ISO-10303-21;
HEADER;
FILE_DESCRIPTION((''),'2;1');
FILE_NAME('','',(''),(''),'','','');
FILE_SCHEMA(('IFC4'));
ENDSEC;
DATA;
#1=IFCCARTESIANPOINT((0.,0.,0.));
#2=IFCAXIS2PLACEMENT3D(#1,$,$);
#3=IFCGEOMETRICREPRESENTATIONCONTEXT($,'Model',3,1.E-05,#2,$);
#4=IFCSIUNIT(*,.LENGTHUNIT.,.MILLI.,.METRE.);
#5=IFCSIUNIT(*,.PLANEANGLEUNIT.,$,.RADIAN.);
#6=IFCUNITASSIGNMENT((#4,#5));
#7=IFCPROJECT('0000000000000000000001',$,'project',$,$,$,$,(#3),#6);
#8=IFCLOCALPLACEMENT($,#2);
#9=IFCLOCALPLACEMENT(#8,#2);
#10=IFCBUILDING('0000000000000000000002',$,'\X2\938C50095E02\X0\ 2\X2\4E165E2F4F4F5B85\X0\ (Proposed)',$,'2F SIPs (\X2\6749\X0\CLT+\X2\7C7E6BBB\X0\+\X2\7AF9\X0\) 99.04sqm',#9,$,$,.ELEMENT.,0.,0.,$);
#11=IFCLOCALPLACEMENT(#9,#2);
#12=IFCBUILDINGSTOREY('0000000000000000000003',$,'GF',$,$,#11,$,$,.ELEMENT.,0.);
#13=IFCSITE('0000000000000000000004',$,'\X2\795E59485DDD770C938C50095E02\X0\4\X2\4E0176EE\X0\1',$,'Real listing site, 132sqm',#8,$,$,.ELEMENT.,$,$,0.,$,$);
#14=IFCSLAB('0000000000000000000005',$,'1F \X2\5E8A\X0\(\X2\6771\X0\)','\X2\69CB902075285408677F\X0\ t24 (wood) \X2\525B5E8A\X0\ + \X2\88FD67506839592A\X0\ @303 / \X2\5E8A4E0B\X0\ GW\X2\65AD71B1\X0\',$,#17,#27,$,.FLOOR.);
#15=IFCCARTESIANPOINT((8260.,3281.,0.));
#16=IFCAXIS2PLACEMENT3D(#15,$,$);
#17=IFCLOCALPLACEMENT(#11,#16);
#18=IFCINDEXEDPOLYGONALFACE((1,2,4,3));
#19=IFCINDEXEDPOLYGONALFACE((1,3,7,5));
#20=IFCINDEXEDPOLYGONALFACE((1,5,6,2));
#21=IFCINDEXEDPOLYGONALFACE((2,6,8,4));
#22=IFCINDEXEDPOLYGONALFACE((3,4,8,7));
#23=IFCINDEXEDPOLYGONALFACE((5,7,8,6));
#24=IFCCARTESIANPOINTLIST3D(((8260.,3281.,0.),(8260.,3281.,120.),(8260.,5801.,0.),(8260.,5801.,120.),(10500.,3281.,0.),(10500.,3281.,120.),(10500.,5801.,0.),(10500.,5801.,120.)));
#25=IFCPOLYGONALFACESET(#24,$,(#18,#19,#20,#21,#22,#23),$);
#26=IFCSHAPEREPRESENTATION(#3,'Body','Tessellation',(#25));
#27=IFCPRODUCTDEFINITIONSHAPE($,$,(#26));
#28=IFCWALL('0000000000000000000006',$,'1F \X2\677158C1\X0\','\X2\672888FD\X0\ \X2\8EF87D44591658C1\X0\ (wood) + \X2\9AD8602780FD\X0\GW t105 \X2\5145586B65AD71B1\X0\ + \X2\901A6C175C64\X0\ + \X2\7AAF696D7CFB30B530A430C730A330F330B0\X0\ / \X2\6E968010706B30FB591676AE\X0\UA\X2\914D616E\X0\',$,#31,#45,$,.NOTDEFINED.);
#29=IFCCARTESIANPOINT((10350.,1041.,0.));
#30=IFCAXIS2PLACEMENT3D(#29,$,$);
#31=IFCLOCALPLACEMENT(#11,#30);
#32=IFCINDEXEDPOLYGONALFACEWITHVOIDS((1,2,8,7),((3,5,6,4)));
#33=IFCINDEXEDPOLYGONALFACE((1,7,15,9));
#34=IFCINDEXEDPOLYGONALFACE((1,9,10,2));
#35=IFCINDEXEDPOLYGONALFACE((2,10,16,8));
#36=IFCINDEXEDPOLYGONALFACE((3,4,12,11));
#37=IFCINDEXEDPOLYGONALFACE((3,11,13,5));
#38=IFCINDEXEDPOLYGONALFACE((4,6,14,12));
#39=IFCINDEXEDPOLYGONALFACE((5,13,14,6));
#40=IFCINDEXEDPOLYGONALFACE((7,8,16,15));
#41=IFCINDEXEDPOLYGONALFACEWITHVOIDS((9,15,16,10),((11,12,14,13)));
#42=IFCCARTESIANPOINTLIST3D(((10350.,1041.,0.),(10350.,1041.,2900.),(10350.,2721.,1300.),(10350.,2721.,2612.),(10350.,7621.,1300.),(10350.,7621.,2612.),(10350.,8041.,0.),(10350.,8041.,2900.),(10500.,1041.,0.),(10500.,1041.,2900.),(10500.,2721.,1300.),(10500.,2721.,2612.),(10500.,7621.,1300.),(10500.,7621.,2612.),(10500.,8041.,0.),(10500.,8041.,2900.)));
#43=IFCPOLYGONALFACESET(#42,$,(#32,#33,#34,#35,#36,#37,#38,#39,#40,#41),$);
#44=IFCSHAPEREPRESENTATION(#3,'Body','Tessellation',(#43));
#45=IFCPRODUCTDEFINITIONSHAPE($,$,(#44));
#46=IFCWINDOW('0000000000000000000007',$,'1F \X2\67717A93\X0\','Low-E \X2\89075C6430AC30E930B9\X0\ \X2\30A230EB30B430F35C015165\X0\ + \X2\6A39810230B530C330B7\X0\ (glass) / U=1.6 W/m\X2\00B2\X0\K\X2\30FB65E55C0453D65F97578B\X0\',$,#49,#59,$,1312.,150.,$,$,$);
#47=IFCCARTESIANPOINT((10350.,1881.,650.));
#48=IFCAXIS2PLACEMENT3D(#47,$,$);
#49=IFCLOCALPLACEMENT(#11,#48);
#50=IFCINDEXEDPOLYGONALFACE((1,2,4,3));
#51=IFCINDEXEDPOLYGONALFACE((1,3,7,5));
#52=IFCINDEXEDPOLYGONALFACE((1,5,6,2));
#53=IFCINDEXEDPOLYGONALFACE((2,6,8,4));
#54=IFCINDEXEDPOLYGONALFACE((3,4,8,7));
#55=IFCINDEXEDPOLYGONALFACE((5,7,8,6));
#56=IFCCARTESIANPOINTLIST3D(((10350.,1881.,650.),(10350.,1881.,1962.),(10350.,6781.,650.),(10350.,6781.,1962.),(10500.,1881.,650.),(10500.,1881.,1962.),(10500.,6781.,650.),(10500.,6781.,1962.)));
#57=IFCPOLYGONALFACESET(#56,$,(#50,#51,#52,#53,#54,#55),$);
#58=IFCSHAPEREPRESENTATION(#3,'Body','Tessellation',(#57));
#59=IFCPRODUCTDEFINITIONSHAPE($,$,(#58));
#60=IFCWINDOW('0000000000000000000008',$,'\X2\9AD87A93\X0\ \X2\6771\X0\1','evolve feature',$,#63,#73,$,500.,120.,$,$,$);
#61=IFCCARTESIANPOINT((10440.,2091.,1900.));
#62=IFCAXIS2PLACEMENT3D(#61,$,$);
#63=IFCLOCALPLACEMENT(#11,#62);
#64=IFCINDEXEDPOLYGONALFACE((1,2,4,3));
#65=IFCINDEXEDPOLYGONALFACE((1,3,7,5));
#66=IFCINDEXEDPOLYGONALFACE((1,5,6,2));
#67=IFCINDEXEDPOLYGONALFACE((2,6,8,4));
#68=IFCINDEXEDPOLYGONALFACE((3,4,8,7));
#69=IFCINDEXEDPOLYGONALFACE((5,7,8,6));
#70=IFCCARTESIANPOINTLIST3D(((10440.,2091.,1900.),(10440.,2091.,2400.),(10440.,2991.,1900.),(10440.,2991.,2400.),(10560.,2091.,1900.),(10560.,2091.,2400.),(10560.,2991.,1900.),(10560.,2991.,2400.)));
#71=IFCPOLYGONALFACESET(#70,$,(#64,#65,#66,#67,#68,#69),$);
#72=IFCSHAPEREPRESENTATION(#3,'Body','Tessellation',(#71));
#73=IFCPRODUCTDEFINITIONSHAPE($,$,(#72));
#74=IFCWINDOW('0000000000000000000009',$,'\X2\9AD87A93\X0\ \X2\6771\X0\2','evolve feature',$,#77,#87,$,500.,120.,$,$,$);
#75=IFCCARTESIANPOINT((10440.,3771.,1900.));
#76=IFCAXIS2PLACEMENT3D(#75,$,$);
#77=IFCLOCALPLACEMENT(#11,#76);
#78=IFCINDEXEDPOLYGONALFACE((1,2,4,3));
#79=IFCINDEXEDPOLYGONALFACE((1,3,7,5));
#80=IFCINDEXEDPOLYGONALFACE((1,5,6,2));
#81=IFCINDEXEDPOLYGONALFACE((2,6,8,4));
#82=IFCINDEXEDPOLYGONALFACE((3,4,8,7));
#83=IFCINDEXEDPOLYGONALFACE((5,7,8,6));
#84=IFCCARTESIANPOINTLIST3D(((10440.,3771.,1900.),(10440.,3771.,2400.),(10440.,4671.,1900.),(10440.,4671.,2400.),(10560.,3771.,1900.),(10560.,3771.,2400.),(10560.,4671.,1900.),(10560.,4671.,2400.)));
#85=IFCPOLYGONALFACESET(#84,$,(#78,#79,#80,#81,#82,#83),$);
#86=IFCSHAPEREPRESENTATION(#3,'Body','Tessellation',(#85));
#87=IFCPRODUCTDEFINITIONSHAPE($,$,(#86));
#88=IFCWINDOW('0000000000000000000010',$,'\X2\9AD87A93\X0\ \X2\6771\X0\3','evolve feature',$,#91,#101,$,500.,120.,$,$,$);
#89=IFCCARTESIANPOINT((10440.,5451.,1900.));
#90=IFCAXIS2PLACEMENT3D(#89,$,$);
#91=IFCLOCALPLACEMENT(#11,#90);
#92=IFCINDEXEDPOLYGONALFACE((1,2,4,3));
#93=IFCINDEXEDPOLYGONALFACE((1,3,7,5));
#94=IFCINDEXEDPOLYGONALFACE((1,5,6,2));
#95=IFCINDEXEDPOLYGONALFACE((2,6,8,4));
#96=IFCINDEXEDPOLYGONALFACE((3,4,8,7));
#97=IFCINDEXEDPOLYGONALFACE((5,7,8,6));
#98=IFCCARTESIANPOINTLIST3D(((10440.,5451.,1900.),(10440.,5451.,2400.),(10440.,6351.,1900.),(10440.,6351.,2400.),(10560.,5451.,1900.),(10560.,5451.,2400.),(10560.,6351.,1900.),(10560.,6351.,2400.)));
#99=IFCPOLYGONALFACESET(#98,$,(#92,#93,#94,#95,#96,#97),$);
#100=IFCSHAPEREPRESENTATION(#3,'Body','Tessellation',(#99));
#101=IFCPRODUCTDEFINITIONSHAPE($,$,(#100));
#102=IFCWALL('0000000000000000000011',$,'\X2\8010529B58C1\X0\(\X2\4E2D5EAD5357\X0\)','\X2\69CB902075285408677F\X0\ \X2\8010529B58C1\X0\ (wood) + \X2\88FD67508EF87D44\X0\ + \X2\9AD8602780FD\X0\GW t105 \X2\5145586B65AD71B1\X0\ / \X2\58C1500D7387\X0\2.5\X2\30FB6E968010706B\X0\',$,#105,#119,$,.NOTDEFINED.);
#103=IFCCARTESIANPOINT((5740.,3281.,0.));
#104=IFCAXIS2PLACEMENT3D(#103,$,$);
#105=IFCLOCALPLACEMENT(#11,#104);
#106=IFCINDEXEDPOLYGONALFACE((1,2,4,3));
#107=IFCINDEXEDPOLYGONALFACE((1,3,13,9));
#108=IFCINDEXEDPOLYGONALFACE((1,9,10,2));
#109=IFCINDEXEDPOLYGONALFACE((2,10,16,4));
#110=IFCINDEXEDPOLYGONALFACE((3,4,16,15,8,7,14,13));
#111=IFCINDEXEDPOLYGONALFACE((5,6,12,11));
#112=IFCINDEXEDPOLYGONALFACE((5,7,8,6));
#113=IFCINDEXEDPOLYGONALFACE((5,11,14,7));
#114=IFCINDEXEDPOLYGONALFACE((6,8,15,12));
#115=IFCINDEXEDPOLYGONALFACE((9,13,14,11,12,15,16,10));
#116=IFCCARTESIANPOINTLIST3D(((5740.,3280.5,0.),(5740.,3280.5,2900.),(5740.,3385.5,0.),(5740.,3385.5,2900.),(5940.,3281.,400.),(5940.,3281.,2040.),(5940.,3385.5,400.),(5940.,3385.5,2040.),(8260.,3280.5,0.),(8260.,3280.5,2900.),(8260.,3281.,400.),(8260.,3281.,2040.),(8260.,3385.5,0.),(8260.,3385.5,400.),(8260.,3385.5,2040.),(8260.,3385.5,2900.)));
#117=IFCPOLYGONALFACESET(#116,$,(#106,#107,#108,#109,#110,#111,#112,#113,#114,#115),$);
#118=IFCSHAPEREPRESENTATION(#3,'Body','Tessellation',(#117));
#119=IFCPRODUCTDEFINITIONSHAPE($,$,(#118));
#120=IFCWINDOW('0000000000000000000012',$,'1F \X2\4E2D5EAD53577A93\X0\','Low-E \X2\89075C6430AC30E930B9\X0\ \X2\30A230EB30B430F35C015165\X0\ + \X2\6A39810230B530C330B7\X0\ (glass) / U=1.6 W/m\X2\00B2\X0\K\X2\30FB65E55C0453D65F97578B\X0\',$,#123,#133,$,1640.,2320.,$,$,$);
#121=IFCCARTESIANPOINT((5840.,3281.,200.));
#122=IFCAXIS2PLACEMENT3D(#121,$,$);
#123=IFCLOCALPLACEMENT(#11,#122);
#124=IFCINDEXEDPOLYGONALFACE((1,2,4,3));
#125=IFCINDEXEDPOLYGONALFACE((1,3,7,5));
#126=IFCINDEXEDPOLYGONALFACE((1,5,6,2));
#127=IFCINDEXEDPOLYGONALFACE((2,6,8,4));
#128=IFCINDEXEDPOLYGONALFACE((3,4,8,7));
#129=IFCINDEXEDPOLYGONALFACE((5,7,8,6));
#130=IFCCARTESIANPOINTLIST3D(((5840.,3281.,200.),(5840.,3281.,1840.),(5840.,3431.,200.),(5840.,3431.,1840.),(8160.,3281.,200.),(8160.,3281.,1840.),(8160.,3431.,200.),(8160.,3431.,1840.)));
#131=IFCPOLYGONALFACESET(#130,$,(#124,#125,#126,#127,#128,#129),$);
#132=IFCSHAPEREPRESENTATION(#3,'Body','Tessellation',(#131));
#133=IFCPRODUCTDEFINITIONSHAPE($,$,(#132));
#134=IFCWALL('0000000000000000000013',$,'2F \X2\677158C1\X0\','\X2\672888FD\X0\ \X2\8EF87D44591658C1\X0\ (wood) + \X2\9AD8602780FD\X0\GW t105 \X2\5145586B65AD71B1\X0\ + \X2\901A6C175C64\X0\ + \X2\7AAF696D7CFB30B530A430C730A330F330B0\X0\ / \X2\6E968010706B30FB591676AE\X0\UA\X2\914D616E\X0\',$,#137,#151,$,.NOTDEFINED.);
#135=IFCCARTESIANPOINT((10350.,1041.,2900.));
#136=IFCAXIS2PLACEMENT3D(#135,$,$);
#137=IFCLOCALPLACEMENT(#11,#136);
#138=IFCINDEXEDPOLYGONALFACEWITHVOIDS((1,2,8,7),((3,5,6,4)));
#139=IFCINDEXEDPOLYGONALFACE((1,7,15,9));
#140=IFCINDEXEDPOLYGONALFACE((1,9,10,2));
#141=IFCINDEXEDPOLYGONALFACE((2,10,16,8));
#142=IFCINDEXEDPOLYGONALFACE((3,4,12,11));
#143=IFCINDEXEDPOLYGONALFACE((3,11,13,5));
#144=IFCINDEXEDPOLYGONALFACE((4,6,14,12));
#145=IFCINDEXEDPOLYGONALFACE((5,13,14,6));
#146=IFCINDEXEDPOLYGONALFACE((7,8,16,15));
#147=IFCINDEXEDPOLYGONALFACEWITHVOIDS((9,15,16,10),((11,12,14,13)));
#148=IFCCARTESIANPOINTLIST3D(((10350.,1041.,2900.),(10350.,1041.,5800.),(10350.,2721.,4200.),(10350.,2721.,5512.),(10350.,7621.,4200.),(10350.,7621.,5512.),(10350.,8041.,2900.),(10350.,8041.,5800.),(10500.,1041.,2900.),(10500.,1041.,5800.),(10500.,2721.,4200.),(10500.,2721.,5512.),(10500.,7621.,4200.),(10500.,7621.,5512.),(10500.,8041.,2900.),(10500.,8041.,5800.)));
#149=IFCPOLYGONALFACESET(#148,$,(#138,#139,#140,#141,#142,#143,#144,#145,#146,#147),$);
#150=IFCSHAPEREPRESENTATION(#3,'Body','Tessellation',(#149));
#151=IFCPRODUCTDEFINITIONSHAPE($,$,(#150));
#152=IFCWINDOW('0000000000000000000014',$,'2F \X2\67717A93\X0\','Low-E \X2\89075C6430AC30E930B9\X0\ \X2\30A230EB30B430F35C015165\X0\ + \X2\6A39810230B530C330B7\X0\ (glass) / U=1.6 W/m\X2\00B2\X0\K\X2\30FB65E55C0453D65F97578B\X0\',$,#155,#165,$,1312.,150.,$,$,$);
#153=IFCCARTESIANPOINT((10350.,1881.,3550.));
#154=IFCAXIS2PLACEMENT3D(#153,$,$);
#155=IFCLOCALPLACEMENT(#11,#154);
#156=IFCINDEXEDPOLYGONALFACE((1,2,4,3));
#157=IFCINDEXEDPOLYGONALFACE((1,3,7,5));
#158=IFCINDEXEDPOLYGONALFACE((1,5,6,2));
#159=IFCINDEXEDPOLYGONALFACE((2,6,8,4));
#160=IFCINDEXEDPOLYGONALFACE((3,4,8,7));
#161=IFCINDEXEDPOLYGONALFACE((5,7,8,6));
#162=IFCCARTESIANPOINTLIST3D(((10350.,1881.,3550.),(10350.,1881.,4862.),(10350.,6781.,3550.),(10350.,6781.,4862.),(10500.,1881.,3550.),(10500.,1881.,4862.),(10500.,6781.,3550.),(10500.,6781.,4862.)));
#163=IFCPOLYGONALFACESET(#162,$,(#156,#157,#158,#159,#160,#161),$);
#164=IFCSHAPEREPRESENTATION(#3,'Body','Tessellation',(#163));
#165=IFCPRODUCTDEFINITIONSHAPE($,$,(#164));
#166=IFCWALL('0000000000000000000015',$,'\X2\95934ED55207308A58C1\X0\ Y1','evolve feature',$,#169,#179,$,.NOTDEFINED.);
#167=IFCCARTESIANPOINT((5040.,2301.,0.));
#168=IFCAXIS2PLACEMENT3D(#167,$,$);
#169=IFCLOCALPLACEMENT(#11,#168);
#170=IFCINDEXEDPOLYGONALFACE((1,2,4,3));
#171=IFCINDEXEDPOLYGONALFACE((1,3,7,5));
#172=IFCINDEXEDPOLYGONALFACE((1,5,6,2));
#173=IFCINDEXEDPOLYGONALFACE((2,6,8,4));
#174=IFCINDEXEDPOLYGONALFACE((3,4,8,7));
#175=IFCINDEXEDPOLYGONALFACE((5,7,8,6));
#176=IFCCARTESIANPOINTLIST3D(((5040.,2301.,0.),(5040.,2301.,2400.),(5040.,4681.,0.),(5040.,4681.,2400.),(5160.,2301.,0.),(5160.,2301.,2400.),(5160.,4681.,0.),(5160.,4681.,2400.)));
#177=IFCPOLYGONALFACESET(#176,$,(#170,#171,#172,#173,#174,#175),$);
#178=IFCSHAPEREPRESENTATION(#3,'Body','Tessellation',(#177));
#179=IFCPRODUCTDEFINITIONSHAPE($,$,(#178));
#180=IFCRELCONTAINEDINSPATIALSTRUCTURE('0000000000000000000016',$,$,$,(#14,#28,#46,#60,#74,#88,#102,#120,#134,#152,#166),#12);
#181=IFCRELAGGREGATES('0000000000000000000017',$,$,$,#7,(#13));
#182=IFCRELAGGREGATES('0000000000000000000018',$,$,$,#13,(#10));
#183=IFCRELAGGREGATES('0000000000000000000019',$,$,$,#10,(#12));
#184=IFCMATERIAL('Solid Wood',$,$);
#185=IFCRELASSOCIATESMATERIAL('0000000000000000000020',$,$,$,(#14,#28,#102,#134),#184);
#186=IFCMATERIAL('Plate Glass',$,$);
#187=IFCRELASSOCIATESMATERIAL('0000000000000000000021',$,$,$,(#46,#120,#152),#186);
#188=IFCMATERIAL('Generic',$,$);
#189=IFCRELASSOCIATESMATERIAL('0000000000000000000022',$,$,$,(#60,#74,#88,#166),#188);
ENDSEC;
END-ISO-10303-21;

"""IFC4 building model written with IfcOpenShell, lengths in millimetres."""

from ifc_helpers import new_model, si_unit, frame, frame_2d, origin, place, context, project, spatial, rectangle, extrude, material, element, fill, save


model = new_model("IFC4")

# Units and contexts
model_context = context("Model", 3, precision=1e-05, world=origin())
ifc_project = project(units=[si_unit("LENGTHUNIT", "METRE", prefix="MILLI"), si_unit("PLANEANGLEUNIT", "RADIAN")], contexts=[model_context])

# Site, building, storey
site_placement = place(None, origin())
site = spatial("IfcSite", under=ifc_project, at=site_placement, Name="神奈川県鎌倉市4丁目1", ObjectType="Real listing site, 132sqm", CompositionType="ELEMENT", RefElevation=0.0)
building_placement = place(site_placement, origin())
building = spatial("IfcBuilding", under=site, at=building_placement, Name="鎌倉市 2世帯住宅 (Proposed)", ObjectType="2F SIPs (杉CLT+籾殻+竹) 99.04sqm", CompositionType="ELEMENT", ElevationOfRefHeight=0.0, ElevationOfTerrain=0.0)
storey_placement = place(building_placement, origin())
storey = spatial("IfcBuildingStorey", under=building, at=storey_placement, Name="GF", CompositionType="ELEMENT", Elevation=0.0)

# Slab
ifc_material_1 = material(Name="Solid Wood")
slab_placement = place(storey_placement, frame((8260.0, 3281.0, 0.0)))
element("IfcSlab", 1, at=slab_placement, inside=storey, material=ifc_material_1, Name="1F 床(東)", Description="構造用合板 t24 (wood) 剛床 + 製材根太 @303 / 床下 GW断熱", PredefinedType="FLOOR", context=model_context, shape_type="SweptSolid", body=[
    extrude(rectangle(XDim=2240.0, YDim=2520.0, at=frame_2d((1120.0, 1260.0))), frame((8260.0, 3281.0, 0.0)), (0.0, 0.0, 1.0), 120.0),
])

# Wall, openings, windows
wall_1_placement = place(storey_placement, frame((10350.0, 1041.0, 0.0)))
wall_1 = element("IfcWall", 2, at=wall_1_placement, inside=storey, material=ifc_material_1, Name="1F 東壁", Description="木製 軸組外壁 (wood) + 高性能GW t105 充填断熱 + 通気層 + 窯業系サイディング / 準耐火・外皮UA配慮", PredefinedType="NOTDEFINED", context=model_context, shape_type="SweptSolid", body=[
    extrude(rectangle(XDim=150.0, YDim=7000.0, at=frame_2d((75.0, 3500.0))), frame((10350.0, 1041.0, 0.0)), (0.0, 0.0, 1.0), 2900.0),
])
opening_1_placement = place(storey_placement, frame((10350.0, 1881.0, 650.0)))
opening_1 = element("IfcOpeningElement", 3, at=opening_1_placement, cuts=wall_1, PredefinedType="NOTDEFINED", context=model_context, shape_type="SweptSolid", body=[
    extrude(rectangle(XDim=150.0, YDim=4900.0, at=frame_2d((75.0, 2450.0))), frame((10350.0, 1881.0, 650.0)), (0.0, 0.0, 1.0), 1312.0),
])
opening_2_placement = place(storey_placement, frame((10440.0, 2091.0, 1900.0)))
opening_2 = element("IfcOpeningElement", 4, at=opening_2_placement, cuts=wall_1, PredefinedType="NOTDEFINED", context=model_context, shape_type="SweptSolid", body=[
    extrude(rectangle(XDim=120.0, YDim=900.0, at=frame_2d((60.0, 450.0))), frame((10440.0, 2091.0, 1900.0)), (0.0, 0.0, 1.0), 500.0),
])
opening_3_placement = place(storey_placement, frame((10440.0, 3771.0, 1900.0)))
opening_3 = element("IfcOpeningElement", 5, at=opening_3_placement, cuts=wall_1, PredefinedType="NOTDEFINED", context=model_context, shape_type="SweptSolid", body=[
    extrude(rectangle(XDim=120.0, YDim=900.0, at=frame_2d((60.0, 450.0))), frame((10440.0, 3771.0, 1900.0)), (0.0, 0.0, 1.0), 500.0),
])
opening_4_placement = place(storey_placement, frame((10440.0, 5451.0, 1900.0)))
opening_4 = element("IfcOpeningElement", 6, at=opening_4_placement, cuts=wall_1, PredefinedType="NOTDEFINED", context=model_context, shape_type="SweptSolid", body=[
    extrude(rectangle(XDim=120.0, YDim=900.0, at=frame_2d((60.0, 450.0))), frame((10440.0, 5451.0, 1900.0)), (0.0, 0.0, 1.0), 500.0),
])
ifc_material_2 = material(Name="Plate Glass")
window_1_placement = place(storey_placement, frame((10350.0, 1881.0, 650.0)))
window_1 = element("IfcWindow", 7, at=window_1_placement, inside=storey, material=ifc_material_2, Name="1F 東窓", Description="Low-E 複層ガラス アルゴン封入 + 樹脂サッシ (glass) / U=1.6 W/m²K・日射取得型", OverallHeight=1312.0, OverallWidth=150.0, context=model_context, shape_type="SweptSolid", body=[
    extrude(rectangle(XDim=150.0, YDim=4900.0, at=frame_2d((75.0, 2450.0))), frame((10350.0, 1881.0, 650.0)), (0.0, 0.0, 1.0), 1312.0),
])
fill(opening_1, window_1)
ifc_material_3 = material(Name="Generic")
window_2_placement = place(storey_placement, frame((10440.0, 2091.0, 1900.0)))
window_2 = element("IfcWindow", 8, at=window_2_placement, inside=storey, material=ifc_material_3, Name="高窓 東1", Description="evolve feature", OverallHeight=500.0, OverallWidth=120.0, context=model_context, shape_type="SweptSolid", body=[
    extrude(rectangle(XDim=120.0, YDim=900.0, at=frame_2d((60.0, 450.0))), frame((10440.0, 2091.0, 1900.0)), (0.0, 0.0, 1.0), 500.0),
])
fill(opening_2, window_2)
window_3_placement = place(storey_placement, frame((10440.0, 3771.0, 1900.0)))
window_3 = element("IfcWindow", 9, at=window_3_placement, inside=storey, material=ifc_material_3, Name="高窓 東2", Description="evolve feature", OverallHeight=500.0, OverallWidth=120.0, context=model_context, shape_type="SweptSolid", body=[
    extrude(rectangle(XDim=120.0, YDim=900.0, at=frame_2d((60.0, 450.0))), frame((10440.0, 3771.0, 1900.0)), (0.0, 0.0, 1.0), 500.0),
])
fill(opening_3, window_3)
window_4_placement = place(storey_placement, frame((10440.0, 5451.0, 1900.0)))
window_4 = element("IfcWindow", 10, at=window_4_placement, inside=storey, material=ifc_material_3, Name="高窓 東3", Description="evolve feature", OverallHeight=500.0, OverallWidth=120.0, context=model_context, shape_type="SweptSolid", body=[
    extrude(rectangle(XDim=120.0, YDim=900.0, at=frame_2d((60.0, 450.0))), frame((10440.0, 5451.0, 1900.0)), (0.0, 0.0, 1.0), 500.0),
])
fill(opening_4, window_4)

# Wall, opening, window
wall_2_placement = place(storey_placement, frame((5740.0, 3281.0, 0.0)))
wall_2 = element("IfcWall", 11, at=wall_2_placement, inside=storey, material=ifc_material_1, Name="耐力壁(中庭南)", Description="構造用合板 耐力壁 (wood) + 製材軸組 + 高性能GW t105 充填断熱 / 壁倍率2.5・準耐火", PredefinedType="NOTDEFINED", context=model_context, shape_type="SweptSolid", body=[
    extrude(rectangle(XDim=2520.0, YDim=105.0, at=frame_2d((1260.0, 52.0))), frame((5740.0, 3281.0, 0.0)), (0.0, 0.0, 1.0), 2900.0),
])
opening_5_placement = place(storey_placement, frame((5840.0, 3281.0, 200.0)))
opening_5 = element("IfcOpeningElement", 12, at=opening_5_placement, cuts=wall_2, PredefinedType="NOTDEFINED", context=model_context, shape_type="SweptSolid", body=[
    extrude(rectangle(XDim=2320.0, YDim=150.0, at=frame_2d((1160.0, 75.0))), frame((5840.0, 3281.0, 200.0)), (0.0, 0.0, 1.0), 1640.0),
])
window_5_placement = place(storey_placement, frame((5840.0, 3281.0, 200.0)))
window_5 = element("IfcWindow", 13, at=window_5_placement, inside=storey, material=ifc_material_2, Name="1F 中庭南窓", Description="Low-E 複層ガラス アルゴン封入 + 樹脂サッシ (glass) / U=1.6 W/m²K・日射取得型", OverallHeight=1640.0, OverallWidth=2320.0, context=model_context, shape_type="SweptSolid", body=[
    extrude(rectangle(XDim=2320.0, YDim=150.0, at=frame_2d((1160.0, 75.0))), frame((5840.0, 3281.0, 200.0)), (0.0, 0.0, 1.0), 1640.0),
])
fill(opening_5, window_5)

# Wall, opening, window
wall_3_placement = place(storey_placement, frame((10350.0, 1041.0, 2900.0)))
wall_3 = element("IfcWall", 14, at=wall_3_placement, inside=storey, material=ifc_material_1, Name="2F 東壁", Description="木製 軸組外壁 (wood) + 高性能GW t105 充填断熱 + 通気層 + 窯業系サイディング / 準耐火・外皮UA配慮", PredefinedType="NOTDEFINED", context=model_context, shape_type="SweptSolid", body=[
    extrude(rectangle(XDim=150.0, YDim=7000.0, at=frame_2d((75.0, 3500.0))), frame((10350.0, 1041.0, 2900.0)), (0.0, 0.0, 1.0), 2900.0),
])
opening_6_placement = place(storey_placement, frame((10350.0, 1881.0, 3550.0)))
opening_6 = element("IfcOpeningElement", 15, at=opening_6_placement, cuts=wall_3, PredefinedType="NOTDEFINED", context=model_context, shape_type="SweptSolid", body=[
    extrude(rectangle(XDim=150.0, YDim=4900.0, at=frame_2d((75.0, 2450.0))), frame((10350.0, 1881.0, 3550.0)), (0.0, 0.0, 1.0), 1312.0),
])
window_6_placement = place(storey_placement, frame((10350.0, 1881.0, 3550.0)))
window_6 = element("IfcWindow", 16, at=window_6_placement, inside=storey, material=ifc_material_2, Name="2F 東窓", Description="Low-E 複層ガラス アルゴン封入 + 樹脂サッシ (glass) / U=1.6 W/m²K・日射取得型", OverallHeight=1312.0, OverallWidth=150.0, context=model_context, shape_type="SweptSolid", body=[
    extrude(rectangle(XDim=150.0, YDim=4900.0, at=frame_2d((75.0, 2450.0))), frame((10350.0, 1881.0, 3550.0)), (0.0, 0.0, 1.0), 1312.0),
])
fill(opening_6, window_6)

# Wall
wall_4_placement = place(storey_placement, frame((5040.0, 2301.0, 0.0)))
element("IfcWall", 17, at=wall_4_placement, inside=storey, material=ifc_material_3, Name="間仕切り壁 Y1", Description="evolve feature", PredefinedType="NOTDEFINED", context=model_context, shape_type="SweptSolid", body=[
    extrude(rectangle(XDim=120.0, YDim=2380.0, at=frame_2d((60.0, 1190.0))), frame((5040.0, 2301.0, 0.0)), (0.0, 0.0, 1.0), 2400.0),
])

save(model, "model.ifc")
